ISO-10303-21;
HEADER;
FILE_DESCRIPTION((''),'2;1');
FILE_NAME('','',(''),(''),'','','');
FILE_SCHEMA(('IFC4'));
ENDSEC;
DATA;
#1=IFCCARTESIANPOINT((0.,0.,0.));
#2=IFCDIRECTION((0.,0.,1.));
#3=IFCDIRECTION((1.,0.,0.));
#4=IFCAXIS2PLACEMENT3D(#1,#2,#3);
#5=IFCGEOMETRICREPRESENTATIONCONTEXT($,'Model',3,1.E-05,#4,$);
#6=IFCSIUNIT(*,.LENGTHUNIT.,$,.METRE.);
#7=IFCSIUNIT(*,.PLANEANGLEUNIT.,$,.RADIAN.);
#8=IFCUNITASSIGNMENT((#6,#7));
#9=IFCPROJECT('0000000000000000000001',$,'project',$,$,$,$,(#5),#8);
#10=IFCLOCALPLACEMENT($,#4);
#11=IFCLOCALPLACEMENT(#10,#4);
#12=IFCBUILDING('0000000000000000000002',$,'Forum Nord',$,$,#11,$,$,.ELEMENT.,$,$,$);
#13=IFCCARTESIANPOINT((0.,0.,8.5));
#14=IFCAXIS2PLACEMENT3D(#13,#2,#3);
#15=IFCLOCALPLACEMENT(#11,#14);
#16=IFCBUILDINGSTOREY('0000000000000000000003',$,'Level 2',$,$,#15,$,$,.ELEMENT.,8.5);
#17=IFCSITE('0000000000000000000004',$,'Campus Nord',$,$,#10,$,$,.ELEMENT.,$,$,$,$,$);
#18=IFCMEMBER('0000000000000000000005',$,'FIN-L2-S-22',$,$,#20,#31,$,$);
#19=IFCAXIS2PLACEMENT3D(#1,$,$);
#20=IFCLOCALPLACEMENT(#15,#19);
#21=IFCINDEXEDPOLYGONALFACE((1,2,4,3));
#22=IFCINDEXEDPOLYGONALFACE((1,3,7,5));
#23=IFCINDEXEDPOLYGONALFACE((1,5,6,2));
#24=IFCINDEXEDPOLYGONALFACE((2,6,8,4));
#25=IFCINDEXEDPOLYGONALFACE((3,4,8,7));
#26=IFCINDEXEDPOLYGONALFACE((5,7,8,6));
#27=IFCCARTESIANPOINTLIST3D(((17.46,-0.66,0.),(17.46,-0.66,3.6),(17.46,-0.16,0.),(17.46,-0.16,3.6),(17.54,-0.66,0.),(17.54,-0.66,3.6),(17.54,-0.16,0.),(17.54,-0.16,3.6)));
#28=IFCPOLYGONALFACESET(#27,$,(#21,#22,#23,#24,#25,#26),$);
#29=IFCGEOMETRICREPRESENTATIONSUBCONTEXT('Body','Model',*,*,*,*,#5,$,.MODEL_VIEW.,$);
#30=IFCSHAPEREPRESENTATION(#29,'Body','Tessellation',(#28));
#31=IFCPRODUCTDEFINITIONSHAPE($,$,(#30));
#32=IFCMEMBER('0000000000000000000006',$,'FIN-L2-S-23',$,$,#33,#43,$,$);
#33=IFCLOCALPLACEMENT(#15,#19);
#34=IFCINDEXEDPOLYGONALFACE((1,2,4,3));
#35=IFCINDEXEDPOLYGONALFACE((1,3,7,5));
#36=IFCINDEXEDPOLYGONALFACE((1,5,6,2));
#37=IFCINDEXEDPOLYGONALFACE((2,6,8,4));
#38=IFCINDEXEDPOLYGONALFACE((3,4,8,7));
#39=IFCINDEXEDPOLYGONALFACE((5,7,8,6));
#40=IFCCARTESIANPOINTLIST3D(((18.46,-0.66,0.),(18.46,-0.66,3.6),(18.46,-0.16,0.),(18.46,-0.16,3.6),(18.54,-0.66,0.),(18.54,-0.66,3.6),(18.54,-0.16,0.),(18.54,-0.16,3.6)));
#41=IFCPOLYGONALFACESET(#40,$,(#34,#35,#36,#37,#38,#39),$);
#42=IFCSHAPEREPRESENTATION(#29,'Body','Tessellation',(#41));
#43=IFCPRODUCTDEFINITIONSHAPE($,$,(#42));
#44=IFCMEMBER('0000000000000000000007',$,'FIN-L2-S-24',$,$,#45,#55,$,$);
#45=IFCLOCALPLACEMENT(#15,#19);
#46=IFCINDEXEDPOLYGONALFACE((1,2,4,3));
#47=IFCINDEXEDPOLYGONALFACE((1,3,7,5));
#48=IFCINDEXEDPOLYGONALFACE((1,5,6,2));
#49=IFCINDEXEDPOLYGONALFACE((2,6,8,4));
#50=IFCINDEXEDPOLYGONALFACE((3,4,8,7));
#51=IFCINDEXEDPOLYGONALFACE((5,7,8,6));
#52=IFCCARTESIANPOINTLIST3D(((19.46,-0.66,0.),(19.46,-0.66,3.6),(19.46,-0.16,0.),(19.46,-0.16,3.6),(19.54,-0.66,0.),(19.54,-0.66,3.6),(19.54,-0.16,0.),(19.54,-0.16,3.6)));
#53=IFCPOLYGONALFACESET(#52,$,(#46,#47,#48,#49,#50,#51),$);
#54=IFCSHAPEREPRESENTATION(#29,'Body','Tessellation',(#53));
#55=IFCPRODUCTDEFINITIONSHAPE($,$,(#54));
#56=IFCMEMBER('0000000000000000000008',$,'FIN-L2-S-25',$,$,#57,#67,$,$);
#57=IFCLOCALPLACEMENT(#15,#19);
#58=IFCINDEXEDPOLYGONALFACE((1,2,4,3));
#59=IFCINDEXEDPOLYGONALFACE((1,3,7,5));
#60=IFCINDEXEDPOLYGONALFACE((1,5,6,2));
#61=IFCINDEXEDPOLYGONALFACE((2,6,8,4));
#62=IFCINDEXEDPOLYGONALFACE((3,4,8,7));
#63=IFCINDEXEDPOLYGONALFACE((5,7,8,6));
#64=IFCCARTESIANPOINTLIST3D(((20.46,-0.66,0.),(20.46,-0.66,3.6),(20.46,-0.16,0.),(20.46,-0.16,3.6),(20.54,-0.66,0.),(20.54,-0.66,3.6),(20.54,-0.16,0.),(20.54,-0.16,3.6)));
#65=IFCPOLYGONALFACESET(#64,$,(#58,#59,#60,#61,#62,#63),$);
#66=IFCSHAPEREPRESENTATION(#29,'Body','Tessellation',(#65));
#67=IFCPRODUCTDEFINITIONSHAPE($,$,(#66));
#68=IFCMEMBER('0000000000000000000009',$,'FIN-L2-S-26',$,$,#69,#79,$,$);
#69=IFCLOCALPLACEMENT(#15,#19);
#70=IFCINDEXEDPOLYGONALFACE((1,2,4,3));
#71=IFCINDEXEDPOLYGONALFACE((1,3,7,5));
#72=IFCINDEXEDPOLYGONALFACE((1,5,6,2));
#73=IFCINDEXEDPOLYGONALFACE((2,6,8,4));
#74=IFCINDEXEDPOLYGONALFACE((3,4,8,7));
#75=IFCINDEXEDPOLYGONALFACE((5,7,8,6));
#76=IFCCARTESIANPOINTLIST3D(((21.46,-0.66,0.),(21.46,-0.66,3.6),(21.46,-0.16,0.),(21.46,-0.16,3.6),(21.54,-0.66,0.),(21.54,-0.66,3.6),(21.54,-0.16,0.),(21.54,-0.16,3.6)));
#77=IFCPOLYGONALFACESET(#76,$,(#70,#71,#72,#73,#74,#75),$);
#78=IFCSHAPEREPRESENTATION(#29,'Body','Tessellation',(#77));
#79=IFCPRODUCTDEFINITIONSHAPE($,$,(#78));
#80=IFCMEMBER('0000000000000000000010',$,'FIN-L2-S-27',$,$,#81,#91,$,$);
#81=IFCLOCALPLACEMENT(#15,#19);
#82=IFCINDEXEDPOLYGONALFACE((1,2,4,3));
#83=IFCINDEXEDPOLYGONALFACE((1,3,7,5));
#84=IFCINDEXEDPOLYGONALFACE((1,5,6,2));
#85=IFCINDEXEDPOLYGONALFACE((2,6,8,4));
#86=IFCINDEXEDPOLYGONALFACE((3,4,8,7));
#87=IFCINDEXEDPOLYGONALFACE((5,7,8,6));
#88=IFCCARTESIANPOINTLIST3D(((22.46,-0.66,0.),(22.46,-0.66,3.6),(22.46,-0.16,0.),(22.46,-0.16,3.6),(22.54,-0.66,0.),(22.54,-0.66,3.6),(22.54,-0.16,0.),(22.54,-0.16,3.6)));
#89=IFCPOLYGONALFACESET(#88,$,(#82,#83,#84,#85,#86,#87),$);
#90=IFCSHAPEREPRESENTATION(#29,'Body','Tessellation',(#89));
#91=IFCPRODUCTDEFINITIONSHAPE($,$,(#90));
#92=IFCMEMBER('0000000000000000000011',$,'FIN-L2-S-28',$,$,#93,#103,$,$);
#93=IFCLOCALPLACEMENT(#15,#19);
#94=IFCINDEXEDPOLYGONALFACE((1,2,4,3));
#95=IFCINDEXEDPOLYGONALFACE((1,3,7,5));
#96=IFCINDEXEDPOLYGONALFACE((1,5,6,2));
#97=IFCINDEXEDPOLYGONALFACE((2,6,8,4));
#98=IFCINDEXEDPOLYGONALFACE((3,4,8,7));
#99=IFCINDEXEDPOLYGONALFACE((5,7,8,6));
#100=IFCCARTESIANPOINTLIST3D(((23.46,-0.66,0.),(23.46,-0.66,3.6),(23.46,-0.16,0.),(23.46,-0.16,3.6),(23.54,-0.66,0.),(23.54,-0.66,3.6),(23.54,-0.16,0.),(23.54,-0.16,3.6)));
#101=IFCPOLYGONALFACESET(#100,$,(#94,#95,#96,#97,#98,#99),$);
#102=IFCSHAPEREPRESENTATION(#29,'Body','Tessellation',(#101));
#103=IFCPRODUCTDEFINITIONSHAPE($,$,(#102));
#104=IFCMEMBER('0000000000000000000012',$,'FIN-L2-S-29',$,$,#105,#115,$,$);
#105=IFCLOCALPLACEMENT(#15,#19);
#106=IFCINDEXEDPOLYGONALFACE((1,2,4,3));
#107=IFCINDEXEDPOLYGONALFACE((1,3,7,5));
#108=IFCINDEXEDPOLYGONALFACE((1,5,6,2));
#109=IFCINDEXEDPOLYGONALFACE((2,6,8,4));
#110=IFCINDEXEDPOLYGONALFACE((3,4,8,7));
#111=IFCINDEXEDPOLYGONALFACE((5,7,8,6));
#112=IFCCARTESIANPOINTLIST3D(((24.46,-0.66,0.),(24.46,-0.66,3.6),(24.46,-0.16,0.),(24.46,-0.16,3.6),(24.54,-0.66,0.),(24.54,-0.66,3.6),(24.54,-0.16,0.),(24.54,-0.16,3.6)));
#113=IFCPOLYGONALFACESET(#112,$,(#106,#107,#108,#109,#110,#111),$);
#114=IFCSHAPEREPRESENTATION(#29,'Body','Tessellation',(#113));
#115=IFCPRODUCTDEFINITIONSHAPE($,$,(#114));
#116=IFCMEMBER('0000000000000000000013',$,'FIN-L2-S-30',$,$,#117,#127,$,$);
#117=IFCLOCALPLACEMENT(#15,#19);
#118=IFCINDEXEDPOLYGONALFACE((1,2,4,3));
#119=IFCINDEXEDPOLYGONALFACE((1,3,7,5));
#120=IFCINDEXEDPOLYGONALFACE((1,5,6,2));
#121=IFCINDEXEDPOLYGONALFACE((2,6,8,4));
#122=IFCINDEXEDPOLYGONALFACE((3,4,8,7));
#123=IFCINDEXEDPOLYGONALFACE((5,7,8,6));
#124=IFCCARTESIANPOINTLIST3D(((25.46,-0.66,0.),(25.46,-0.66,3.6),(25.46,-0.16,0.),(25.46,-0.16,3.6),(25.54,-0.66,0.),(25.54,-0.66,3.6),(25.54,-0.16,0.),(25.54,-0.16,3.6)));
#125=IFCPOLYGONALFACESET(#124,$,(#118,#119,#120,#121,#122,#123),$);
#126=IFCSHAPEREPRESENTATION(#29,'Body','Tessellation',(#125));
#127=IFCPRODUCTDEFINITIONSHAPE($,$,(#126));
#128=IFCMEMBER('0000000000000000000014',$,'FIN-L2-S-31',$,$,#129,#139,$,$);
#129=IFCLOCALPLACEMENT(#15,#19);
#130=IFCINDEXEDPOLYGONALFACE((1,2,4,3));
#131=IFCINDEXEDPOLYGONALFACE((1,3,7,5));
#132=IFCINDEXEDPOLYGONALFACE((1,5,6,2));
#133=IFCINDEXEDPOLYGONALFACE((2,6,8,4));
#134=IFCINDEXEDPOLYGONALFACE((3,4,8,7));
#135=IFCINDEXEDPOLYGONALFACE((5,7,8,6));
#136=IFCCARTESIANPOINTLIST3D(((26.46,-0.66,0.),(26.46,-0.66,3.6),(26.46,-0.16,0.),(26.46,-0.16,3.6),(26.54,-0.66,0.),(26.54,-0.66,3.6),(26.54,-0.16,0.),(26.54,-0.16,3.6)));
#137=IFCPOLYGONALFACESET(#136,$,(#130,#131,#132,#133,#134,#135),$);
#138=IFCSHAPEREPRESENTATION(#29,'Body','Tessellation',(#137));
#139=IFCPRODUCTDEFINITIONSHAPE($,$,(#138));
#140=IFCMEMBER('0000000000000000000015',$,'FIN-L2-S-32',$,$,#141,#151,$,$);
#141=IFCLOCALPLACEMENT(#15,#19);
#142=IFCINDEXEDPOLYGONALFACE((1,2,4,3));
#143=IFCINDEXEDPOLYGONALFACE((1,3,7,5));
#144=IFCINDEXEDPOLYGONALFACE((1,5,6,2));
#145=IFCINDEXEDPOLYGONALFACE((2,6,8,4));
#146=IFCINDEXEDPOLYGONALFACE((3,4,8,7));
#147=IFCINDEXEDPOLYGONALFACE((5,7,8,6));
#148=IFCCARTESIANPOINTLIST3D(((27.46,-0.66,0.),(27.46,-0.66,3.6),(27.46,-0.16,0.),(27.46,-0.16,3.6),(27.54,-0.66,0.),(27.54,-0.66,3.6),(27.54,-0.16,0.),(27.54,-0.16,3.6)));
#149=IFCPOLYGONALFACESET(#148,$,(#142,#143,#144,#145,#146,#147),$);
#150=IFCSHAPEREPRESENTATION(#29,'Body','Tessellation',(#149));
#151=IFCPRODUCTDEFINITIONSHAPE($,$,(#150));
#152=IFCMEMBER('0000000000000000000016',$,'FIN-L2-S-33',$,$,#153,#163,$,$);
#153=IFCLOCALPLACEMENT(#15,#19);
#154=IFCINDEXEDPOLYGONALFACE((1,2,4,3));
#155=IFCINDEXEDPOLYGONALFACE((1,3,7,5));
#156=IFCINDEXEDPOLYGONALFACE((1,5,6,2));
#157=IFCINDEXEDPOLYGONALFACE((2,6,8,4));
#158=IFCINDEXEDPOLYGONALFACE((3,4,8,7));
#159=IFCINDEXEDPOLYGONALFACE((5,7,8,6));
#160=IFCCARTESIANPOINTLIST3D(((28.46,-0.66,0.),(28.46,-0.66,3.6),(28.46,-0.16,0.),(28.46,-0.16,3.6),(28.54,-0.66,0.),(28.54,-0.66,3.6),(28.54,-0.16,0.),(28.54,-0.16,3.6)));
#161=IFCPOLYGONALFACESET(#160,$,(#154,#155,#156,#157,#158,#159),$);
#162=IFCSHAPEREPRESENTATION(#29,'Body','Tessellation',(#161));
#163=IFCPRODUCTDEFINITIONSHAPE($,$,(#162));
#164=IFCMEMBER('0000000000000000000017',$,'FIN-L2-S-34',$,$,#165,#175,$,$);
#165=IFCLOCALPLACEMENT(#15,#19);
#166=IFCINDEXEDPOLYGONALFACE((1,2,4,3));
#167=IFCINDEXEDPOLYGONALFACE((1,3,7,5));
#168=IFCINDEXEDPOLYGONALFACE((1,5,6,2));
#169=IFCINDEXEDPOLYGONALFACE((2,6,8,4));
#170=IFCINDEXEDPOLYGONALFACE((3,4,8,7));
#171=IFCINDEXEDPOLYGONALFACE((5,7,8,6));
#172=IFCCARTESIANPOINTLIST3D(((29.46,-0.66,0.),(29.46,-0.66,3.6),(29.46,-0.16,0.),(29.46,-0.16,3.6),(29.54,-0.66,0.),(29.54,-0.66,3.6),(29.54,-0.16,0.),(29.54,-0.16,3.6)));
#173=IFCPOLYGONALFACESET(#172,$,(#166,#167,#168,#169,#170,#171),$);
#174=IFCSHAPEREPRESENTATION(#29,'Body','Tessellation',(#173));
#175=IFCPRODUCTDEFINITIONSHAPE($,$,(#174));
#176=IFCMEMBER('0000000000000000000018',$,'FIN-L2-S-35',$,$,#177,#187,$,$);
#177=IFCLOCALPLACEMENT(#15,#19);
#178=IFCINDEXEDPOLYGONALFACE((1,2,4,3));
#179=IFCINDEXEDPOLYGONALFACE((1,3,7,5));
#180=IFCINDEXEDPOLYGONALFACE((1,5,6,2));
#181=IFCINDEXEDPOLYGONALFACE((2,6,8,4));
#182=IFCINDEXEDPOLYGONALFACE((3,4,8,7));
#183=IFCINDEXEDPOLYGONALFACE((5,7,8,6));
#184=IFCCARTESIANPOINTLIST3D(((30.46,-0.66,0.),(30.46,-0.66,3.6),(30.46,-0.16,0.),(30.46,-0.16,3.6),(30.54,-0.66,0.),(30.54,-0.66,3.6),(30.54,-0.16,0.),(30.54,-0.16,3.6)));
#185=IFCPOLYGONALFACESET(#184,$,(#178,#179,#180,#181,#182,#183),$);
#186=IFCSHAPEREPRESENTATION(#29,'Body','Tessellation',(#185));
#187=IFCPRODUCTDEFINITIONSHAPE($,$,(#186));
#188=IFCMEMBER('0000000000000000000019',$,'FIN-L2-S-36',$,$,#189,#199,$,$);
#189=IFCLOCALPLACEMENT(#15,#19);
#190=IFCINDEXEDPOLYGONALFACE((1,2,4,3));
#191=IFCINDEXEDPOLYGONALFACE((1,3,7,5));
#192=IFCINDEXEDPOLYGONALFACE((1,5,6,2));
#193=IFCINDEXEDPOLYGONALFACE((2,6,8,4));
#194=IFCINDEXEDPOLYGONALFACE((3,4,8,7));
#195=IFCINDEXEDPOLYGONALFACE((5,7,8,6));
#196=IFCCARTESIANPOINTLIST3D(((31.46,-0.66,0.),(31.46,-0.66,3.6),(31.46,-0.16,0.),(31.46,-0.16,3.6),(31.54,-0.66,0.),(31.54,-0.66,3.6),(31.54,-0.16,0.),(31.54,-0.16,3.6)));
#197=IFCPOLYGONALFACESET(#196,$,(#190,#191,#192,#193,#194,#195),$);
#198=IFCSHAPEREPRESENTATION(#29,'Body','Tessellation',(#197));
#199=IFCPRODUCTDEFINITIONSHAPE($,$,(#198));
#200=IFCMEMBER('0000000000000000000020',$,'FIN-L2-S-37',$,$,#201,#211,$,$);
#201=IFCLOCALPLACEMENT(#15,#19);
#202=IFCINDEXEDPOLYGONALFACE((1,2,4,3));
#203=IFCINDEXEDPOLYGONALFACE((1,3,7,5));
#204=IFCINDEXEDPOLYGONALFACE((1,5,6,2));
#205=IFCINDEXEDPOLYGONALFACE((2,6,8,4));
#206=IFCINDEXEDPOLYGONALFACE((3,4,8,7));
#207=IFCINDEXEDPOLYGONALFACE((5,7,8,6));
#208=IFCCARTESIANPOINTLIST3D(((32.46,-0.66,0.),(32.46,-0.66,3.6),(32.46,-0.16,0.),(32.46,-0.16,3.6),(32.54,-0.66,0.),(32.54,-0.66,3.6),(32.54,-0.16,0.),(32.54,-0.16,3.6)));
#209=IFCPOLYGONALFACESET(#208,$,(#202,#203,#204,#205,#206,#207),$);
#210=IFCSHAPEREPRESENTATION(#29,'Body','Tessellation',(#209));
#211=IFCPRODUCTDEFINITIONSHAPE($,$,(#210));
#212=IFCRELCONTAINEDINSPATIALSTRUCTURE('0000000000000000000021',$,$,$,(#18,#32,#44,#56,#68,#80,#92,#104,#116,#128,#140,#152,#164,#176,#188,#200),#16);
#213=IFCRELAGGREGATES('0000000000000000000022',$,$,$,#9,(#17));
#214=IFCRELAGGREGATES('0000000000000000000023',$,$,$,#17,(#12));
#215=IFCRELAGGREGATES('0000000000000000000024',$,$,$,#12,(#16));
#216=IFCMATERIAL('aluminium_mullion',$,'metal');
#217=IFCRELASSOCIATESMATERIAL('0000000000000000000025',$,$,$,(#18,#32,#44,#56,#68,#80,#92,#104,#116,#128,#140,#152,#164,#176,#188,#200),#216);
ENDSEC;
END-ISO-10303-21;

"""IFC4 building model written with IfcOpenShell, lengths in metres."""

from ifc_helpers import new_model, si_unit, frame, origin_with_axes, place, context, subcontext, project, spatial, polyline, outline, extrude, material, element, save


model = new_model("IFC4")

# Units and contexts
model_context = context("Model", 3, precision=1e-05, world=origin_with_axes())
body_context = subcontext(model_context, "Body", "Model", "MODEL_VIEW")
ifc_project = project(units=[si_unit("LENGTHUNIT", "METRE"), si_unit("PLANEANGLEUNIT", "RADIAN")], contexts=[model_context])

# Site, building, storey
site_placement = place(None, origin_with_axes())
site = spatial("IfcSite", under=ifc_project, at=site_placement, Name="Campus Nord", CompositionType="ELEMENT")
building_placement = place(site_placement, origin_with_axes())
building = spatial("IfcBuilding", under=site, at=building_placement, Name="Forum Nord", CompositionType="ELEMENT")
storey_placement = place(building_placement, frame((0.0, 0.0, 8.5), z_axis=(0.0, 0.0, 1.0), x_axis=(1.0, 0.0, 0.0)))
storey = spatial("IfcBuildingStorey", under=building, at=storey_placement, Name="Level 2", CompositionType="ELEMENT", Elevation=8.5)

# Members
ifc_material_1 = material(Name="aluminium_mullion", Category="metal")
member_1_placement = place(storey_placement, origin_with_axes())
element("IfcMember", 1, at=member_1_placement, inside=storey, material=ifc_material_1, Name="FIN-L2-S-22", context=body_context, shape_type="SweptSolid", body=[
    extrude(outline(polyline([(17.46, -0.66), (17.54, -0.66), (17.54, -0.16), (17.46, -0.16), (17.46, -0.66)])), origin_with_axes(), (0.0, 0.0, 1.0), 3.6),
])
member_2_placement = place(storey_placement, origin_with_axes())
element("IfcMember", 2, at=member_2_placement, inside=storey, material=ifc_material_1, Name="FIN-L2-S-23", context=body_context, shape_type="SweptSolid", body=[
    extrude(outline(polyline([(18.46, -0.66), (18.54, -0.66), (18.54, -0.16), (18.46, -0.16), (18.46, -0.66)])), origin_with_axes(), (0.0, 0.0, 1.0), 3.6),
])
member_3_placement = place(storey_placement, origin_with_axes())
element("IfcMember", 3, at=member_3_placement, inside=storey, material=ifc_material_1, Name="FIN-L2-S-24", context=body_context, shape_type="SweptSolid", body=[
    extrude(outline(polyline([(19.46, -0.66), (19.54, -0.66), (19.54, -0.16), (19.46, -0.16), (19.46, -0.66)])), origin_with_axes(), (0.0, 0.0, 1.0), 3.6),
])
member_4_placement = place(storey_placement, origin_with_axes())
element("IfcMember", 4, at=member_4_placement, inside=storey, material=ifc_material_1, Name="FIN-L2-S-25", context=body_context, shape_type="SweptSolid", body=[
    extrude(outline(polyline([(20.46, -0.66), (20.54, -0.66), (20.54, -0.16), (20.46, -0.16), (20.46, -0.66)])), origin_with_axes(), (0.0, 0.0, 1.0), 3.6),
])
member_5_placement = place(storey_placement, origin_with_axes())
element("IfcMember", 5, at=member_5_placement, inside=storey, material=ifc_material_1, Name="FIN-L2-S-26", context=body_context, shape_type="SweptSolid", body=[
    extrude(outline(polyline([(21.46, -0.66), (21.54, -0.66), (21.54, -0.16), (21.46, -0.16), (21.46, -0.66)])), origin_with_axes(), (0.0, 0.0, 1.0), 3.6),
])
member_6_placement = place(storey_placement, origin_with_axes())
element("IfcMember", 6, at=member_6_placement, inside=storey, material=ifc_material_1, Name="FIN-L2-S-27", context=body_context, shape_type="SweptSolid", body=[
    extrude(outline(polyline([(22.46, -0.66), (22.54, -0.66), (22.54, -0.16), (22.46, -0.16), (22.46, -0.66)])), origin_with_axes(), (0.0, 0.0, 1.0), 3.6),
])
member_7_placement = place(storey_placement, origin_with_axes())
element("IfcMember", 7, at=member_7_placement, inside=storey, material=ifc_material_1, Name="FIN-L2-S-28", context=body_context, shape_type="SweptSolid", body=[
    extrude(outline(polyline([(23.46, -0.66), (23.54, -0.66), (23.54, -0.16), (23.46, -0.16), (23.46, -0.66)])), origin_with_axes(), (0.0, 0.0, 1.0), 3.6),
])
member_8_placement = place(storey_placement, origin_with_axes())
element("IfcMember", 8, at=member_8_placement, inside=storey, material=ifc_material_1, Name="FIN-L2-S-29", context=body_context, shape_type="SweptSolid", body=[
    extrude(outline(polyline([(24.46, -0.66), (24.54, -0.66), (24.54, -0.16), (24.46, -0.16), (24.46, -0.66)])), origin_with_axes(), (0.0, 0.0, 1.0), 3.6),
])
member_9_placement = place(storey_placement, origin_with_axes())
element("IfcMember", 9, at=member_9_placement, inside=storey, material=ifc_material_1, Name="FIN-L2-S-30", context=body_context, shape_type="SweptSolid", body=[
    extrude(outline(polyline([(25.46, -0.66), (25.54, -0.66), (25.54, -0.16), (25.46, -0.16), (25.46, -0.66)])), origin_with_axes(), (0.0, 0.0, 1.0), 3.6),
])
member_10_placement = place(storey_placement, origin_with_axes())
element("IfcMember", 10, at=member_10_placement, inside=storey, material=ifc_material_1, Name="FIN-L2-S-31", context=body_context, shape_type="SweptSolid", body=[
    extrude(outline(polyline([(26.46, -0.66), (26.54, -0.66), (26.54, -0.16), (26.46, -0.16), (26.46, -0.66)])), origin_with_axes(), (0.0, 0.0, 1.0), 3.6),
])
member_11_placement = place(storey_placement, origin_with_axes())
element("IfcMember", 11, at=member_11_placement, inside=storey, material=ifc_material_1, Name="FIN-L2-S-32", context=body_context, shape_type="SweptSolid", body=[
    extrude(outline(polyline([(27.46, -0.66), (27.54, -0.66), (27.54, -0.16), (27.46, -0.16), (27.46, -0.66)])), origin_with_axes(), (0.0, 0.0, 1.0), 3.6),
])
member_12_placement = place(storey_placement, origin_with_axes())
element("IfcMember", 12, at=member_12_placement, inside=storey, material=ifc_material_1, Name="FIN-L2-S-33", context=body_context, shape_type="SweptSolid", body=[
    extrude(outline(polyline([(28.46, -0.66), (28.54, -0.66), (28.54, -0.16), (28.46, -0.16), (28.46, -0.66)])), origin_with_axes(), (0.0, 0.0, 1.0), 3.6),
])
member_13_placement = place(storey_placement, origin_with_axes())
element("IfcMember", 13, at=member_13_placement, inside=storey, material=ifc_material_1, Name="FIN-L2-S-34", context=body_context, shape_type="SweptSolid", body=[
    extrude(outline(polyline([(29.46, -0.66), (29.54, -0.66), (29.54, -0.16), (29.46, -0.16), (29.46, -0.66)])), origin_with_axes(), (0.0, 0.0, 1.0), 3.6),
])
member_14_placement = place(storey_placement, origin_with_axes())
element("IfcMember", 14, at=member_14_placement, inside=storey, material=ifc_material_1, Name="FIN-L2-S-35", context=body_context, shape_type="SweptSolid", body=[
    extrude(outline(polyline([(30.46, -0.66), (30.54, -0.66), (30.54, -0.16), (30.46, -0.16), (30.46, -0.66)])), origin_with_axes(), (0.0, 0.0, 1.0), 3.6),
])
member_15_placement = place(storey_placement, origin_with_axes())
element("IfcMember", 15, at=member_15_placement, inside=storey, material=ifc_material_1, Name="FIN-L2-S-36", context=body_context, shape_type="SweptSolid", body=[
    extrude(outline(polyline([(31.46, -0.66), (31.54, -0.66), (31.54, -0.16), (31.46, -0.16), (31.46, -0.66)])), origin_with_axes(), (0.0, 0.0, 1.0), 3.6),
])
member_16_placement = place(storey_placement, origin_with_axes())
element("IfcMember", 16, at=member_16_placement, inside=storey, material=ifc_material_1, Name="FIN-L2-S-37", context=body_context, shape_type="SweptSolid", body=[
    extrude(outline(polyline([(32.46, -0.66), (32.54, -0.66), (32.54, -0.16), (32.46, -0.16), (32.46, -0.66)])), origin_with_axes(), (0.0, 0.0, 1.0), 3.6),
])

save(model, "model.ifc")
